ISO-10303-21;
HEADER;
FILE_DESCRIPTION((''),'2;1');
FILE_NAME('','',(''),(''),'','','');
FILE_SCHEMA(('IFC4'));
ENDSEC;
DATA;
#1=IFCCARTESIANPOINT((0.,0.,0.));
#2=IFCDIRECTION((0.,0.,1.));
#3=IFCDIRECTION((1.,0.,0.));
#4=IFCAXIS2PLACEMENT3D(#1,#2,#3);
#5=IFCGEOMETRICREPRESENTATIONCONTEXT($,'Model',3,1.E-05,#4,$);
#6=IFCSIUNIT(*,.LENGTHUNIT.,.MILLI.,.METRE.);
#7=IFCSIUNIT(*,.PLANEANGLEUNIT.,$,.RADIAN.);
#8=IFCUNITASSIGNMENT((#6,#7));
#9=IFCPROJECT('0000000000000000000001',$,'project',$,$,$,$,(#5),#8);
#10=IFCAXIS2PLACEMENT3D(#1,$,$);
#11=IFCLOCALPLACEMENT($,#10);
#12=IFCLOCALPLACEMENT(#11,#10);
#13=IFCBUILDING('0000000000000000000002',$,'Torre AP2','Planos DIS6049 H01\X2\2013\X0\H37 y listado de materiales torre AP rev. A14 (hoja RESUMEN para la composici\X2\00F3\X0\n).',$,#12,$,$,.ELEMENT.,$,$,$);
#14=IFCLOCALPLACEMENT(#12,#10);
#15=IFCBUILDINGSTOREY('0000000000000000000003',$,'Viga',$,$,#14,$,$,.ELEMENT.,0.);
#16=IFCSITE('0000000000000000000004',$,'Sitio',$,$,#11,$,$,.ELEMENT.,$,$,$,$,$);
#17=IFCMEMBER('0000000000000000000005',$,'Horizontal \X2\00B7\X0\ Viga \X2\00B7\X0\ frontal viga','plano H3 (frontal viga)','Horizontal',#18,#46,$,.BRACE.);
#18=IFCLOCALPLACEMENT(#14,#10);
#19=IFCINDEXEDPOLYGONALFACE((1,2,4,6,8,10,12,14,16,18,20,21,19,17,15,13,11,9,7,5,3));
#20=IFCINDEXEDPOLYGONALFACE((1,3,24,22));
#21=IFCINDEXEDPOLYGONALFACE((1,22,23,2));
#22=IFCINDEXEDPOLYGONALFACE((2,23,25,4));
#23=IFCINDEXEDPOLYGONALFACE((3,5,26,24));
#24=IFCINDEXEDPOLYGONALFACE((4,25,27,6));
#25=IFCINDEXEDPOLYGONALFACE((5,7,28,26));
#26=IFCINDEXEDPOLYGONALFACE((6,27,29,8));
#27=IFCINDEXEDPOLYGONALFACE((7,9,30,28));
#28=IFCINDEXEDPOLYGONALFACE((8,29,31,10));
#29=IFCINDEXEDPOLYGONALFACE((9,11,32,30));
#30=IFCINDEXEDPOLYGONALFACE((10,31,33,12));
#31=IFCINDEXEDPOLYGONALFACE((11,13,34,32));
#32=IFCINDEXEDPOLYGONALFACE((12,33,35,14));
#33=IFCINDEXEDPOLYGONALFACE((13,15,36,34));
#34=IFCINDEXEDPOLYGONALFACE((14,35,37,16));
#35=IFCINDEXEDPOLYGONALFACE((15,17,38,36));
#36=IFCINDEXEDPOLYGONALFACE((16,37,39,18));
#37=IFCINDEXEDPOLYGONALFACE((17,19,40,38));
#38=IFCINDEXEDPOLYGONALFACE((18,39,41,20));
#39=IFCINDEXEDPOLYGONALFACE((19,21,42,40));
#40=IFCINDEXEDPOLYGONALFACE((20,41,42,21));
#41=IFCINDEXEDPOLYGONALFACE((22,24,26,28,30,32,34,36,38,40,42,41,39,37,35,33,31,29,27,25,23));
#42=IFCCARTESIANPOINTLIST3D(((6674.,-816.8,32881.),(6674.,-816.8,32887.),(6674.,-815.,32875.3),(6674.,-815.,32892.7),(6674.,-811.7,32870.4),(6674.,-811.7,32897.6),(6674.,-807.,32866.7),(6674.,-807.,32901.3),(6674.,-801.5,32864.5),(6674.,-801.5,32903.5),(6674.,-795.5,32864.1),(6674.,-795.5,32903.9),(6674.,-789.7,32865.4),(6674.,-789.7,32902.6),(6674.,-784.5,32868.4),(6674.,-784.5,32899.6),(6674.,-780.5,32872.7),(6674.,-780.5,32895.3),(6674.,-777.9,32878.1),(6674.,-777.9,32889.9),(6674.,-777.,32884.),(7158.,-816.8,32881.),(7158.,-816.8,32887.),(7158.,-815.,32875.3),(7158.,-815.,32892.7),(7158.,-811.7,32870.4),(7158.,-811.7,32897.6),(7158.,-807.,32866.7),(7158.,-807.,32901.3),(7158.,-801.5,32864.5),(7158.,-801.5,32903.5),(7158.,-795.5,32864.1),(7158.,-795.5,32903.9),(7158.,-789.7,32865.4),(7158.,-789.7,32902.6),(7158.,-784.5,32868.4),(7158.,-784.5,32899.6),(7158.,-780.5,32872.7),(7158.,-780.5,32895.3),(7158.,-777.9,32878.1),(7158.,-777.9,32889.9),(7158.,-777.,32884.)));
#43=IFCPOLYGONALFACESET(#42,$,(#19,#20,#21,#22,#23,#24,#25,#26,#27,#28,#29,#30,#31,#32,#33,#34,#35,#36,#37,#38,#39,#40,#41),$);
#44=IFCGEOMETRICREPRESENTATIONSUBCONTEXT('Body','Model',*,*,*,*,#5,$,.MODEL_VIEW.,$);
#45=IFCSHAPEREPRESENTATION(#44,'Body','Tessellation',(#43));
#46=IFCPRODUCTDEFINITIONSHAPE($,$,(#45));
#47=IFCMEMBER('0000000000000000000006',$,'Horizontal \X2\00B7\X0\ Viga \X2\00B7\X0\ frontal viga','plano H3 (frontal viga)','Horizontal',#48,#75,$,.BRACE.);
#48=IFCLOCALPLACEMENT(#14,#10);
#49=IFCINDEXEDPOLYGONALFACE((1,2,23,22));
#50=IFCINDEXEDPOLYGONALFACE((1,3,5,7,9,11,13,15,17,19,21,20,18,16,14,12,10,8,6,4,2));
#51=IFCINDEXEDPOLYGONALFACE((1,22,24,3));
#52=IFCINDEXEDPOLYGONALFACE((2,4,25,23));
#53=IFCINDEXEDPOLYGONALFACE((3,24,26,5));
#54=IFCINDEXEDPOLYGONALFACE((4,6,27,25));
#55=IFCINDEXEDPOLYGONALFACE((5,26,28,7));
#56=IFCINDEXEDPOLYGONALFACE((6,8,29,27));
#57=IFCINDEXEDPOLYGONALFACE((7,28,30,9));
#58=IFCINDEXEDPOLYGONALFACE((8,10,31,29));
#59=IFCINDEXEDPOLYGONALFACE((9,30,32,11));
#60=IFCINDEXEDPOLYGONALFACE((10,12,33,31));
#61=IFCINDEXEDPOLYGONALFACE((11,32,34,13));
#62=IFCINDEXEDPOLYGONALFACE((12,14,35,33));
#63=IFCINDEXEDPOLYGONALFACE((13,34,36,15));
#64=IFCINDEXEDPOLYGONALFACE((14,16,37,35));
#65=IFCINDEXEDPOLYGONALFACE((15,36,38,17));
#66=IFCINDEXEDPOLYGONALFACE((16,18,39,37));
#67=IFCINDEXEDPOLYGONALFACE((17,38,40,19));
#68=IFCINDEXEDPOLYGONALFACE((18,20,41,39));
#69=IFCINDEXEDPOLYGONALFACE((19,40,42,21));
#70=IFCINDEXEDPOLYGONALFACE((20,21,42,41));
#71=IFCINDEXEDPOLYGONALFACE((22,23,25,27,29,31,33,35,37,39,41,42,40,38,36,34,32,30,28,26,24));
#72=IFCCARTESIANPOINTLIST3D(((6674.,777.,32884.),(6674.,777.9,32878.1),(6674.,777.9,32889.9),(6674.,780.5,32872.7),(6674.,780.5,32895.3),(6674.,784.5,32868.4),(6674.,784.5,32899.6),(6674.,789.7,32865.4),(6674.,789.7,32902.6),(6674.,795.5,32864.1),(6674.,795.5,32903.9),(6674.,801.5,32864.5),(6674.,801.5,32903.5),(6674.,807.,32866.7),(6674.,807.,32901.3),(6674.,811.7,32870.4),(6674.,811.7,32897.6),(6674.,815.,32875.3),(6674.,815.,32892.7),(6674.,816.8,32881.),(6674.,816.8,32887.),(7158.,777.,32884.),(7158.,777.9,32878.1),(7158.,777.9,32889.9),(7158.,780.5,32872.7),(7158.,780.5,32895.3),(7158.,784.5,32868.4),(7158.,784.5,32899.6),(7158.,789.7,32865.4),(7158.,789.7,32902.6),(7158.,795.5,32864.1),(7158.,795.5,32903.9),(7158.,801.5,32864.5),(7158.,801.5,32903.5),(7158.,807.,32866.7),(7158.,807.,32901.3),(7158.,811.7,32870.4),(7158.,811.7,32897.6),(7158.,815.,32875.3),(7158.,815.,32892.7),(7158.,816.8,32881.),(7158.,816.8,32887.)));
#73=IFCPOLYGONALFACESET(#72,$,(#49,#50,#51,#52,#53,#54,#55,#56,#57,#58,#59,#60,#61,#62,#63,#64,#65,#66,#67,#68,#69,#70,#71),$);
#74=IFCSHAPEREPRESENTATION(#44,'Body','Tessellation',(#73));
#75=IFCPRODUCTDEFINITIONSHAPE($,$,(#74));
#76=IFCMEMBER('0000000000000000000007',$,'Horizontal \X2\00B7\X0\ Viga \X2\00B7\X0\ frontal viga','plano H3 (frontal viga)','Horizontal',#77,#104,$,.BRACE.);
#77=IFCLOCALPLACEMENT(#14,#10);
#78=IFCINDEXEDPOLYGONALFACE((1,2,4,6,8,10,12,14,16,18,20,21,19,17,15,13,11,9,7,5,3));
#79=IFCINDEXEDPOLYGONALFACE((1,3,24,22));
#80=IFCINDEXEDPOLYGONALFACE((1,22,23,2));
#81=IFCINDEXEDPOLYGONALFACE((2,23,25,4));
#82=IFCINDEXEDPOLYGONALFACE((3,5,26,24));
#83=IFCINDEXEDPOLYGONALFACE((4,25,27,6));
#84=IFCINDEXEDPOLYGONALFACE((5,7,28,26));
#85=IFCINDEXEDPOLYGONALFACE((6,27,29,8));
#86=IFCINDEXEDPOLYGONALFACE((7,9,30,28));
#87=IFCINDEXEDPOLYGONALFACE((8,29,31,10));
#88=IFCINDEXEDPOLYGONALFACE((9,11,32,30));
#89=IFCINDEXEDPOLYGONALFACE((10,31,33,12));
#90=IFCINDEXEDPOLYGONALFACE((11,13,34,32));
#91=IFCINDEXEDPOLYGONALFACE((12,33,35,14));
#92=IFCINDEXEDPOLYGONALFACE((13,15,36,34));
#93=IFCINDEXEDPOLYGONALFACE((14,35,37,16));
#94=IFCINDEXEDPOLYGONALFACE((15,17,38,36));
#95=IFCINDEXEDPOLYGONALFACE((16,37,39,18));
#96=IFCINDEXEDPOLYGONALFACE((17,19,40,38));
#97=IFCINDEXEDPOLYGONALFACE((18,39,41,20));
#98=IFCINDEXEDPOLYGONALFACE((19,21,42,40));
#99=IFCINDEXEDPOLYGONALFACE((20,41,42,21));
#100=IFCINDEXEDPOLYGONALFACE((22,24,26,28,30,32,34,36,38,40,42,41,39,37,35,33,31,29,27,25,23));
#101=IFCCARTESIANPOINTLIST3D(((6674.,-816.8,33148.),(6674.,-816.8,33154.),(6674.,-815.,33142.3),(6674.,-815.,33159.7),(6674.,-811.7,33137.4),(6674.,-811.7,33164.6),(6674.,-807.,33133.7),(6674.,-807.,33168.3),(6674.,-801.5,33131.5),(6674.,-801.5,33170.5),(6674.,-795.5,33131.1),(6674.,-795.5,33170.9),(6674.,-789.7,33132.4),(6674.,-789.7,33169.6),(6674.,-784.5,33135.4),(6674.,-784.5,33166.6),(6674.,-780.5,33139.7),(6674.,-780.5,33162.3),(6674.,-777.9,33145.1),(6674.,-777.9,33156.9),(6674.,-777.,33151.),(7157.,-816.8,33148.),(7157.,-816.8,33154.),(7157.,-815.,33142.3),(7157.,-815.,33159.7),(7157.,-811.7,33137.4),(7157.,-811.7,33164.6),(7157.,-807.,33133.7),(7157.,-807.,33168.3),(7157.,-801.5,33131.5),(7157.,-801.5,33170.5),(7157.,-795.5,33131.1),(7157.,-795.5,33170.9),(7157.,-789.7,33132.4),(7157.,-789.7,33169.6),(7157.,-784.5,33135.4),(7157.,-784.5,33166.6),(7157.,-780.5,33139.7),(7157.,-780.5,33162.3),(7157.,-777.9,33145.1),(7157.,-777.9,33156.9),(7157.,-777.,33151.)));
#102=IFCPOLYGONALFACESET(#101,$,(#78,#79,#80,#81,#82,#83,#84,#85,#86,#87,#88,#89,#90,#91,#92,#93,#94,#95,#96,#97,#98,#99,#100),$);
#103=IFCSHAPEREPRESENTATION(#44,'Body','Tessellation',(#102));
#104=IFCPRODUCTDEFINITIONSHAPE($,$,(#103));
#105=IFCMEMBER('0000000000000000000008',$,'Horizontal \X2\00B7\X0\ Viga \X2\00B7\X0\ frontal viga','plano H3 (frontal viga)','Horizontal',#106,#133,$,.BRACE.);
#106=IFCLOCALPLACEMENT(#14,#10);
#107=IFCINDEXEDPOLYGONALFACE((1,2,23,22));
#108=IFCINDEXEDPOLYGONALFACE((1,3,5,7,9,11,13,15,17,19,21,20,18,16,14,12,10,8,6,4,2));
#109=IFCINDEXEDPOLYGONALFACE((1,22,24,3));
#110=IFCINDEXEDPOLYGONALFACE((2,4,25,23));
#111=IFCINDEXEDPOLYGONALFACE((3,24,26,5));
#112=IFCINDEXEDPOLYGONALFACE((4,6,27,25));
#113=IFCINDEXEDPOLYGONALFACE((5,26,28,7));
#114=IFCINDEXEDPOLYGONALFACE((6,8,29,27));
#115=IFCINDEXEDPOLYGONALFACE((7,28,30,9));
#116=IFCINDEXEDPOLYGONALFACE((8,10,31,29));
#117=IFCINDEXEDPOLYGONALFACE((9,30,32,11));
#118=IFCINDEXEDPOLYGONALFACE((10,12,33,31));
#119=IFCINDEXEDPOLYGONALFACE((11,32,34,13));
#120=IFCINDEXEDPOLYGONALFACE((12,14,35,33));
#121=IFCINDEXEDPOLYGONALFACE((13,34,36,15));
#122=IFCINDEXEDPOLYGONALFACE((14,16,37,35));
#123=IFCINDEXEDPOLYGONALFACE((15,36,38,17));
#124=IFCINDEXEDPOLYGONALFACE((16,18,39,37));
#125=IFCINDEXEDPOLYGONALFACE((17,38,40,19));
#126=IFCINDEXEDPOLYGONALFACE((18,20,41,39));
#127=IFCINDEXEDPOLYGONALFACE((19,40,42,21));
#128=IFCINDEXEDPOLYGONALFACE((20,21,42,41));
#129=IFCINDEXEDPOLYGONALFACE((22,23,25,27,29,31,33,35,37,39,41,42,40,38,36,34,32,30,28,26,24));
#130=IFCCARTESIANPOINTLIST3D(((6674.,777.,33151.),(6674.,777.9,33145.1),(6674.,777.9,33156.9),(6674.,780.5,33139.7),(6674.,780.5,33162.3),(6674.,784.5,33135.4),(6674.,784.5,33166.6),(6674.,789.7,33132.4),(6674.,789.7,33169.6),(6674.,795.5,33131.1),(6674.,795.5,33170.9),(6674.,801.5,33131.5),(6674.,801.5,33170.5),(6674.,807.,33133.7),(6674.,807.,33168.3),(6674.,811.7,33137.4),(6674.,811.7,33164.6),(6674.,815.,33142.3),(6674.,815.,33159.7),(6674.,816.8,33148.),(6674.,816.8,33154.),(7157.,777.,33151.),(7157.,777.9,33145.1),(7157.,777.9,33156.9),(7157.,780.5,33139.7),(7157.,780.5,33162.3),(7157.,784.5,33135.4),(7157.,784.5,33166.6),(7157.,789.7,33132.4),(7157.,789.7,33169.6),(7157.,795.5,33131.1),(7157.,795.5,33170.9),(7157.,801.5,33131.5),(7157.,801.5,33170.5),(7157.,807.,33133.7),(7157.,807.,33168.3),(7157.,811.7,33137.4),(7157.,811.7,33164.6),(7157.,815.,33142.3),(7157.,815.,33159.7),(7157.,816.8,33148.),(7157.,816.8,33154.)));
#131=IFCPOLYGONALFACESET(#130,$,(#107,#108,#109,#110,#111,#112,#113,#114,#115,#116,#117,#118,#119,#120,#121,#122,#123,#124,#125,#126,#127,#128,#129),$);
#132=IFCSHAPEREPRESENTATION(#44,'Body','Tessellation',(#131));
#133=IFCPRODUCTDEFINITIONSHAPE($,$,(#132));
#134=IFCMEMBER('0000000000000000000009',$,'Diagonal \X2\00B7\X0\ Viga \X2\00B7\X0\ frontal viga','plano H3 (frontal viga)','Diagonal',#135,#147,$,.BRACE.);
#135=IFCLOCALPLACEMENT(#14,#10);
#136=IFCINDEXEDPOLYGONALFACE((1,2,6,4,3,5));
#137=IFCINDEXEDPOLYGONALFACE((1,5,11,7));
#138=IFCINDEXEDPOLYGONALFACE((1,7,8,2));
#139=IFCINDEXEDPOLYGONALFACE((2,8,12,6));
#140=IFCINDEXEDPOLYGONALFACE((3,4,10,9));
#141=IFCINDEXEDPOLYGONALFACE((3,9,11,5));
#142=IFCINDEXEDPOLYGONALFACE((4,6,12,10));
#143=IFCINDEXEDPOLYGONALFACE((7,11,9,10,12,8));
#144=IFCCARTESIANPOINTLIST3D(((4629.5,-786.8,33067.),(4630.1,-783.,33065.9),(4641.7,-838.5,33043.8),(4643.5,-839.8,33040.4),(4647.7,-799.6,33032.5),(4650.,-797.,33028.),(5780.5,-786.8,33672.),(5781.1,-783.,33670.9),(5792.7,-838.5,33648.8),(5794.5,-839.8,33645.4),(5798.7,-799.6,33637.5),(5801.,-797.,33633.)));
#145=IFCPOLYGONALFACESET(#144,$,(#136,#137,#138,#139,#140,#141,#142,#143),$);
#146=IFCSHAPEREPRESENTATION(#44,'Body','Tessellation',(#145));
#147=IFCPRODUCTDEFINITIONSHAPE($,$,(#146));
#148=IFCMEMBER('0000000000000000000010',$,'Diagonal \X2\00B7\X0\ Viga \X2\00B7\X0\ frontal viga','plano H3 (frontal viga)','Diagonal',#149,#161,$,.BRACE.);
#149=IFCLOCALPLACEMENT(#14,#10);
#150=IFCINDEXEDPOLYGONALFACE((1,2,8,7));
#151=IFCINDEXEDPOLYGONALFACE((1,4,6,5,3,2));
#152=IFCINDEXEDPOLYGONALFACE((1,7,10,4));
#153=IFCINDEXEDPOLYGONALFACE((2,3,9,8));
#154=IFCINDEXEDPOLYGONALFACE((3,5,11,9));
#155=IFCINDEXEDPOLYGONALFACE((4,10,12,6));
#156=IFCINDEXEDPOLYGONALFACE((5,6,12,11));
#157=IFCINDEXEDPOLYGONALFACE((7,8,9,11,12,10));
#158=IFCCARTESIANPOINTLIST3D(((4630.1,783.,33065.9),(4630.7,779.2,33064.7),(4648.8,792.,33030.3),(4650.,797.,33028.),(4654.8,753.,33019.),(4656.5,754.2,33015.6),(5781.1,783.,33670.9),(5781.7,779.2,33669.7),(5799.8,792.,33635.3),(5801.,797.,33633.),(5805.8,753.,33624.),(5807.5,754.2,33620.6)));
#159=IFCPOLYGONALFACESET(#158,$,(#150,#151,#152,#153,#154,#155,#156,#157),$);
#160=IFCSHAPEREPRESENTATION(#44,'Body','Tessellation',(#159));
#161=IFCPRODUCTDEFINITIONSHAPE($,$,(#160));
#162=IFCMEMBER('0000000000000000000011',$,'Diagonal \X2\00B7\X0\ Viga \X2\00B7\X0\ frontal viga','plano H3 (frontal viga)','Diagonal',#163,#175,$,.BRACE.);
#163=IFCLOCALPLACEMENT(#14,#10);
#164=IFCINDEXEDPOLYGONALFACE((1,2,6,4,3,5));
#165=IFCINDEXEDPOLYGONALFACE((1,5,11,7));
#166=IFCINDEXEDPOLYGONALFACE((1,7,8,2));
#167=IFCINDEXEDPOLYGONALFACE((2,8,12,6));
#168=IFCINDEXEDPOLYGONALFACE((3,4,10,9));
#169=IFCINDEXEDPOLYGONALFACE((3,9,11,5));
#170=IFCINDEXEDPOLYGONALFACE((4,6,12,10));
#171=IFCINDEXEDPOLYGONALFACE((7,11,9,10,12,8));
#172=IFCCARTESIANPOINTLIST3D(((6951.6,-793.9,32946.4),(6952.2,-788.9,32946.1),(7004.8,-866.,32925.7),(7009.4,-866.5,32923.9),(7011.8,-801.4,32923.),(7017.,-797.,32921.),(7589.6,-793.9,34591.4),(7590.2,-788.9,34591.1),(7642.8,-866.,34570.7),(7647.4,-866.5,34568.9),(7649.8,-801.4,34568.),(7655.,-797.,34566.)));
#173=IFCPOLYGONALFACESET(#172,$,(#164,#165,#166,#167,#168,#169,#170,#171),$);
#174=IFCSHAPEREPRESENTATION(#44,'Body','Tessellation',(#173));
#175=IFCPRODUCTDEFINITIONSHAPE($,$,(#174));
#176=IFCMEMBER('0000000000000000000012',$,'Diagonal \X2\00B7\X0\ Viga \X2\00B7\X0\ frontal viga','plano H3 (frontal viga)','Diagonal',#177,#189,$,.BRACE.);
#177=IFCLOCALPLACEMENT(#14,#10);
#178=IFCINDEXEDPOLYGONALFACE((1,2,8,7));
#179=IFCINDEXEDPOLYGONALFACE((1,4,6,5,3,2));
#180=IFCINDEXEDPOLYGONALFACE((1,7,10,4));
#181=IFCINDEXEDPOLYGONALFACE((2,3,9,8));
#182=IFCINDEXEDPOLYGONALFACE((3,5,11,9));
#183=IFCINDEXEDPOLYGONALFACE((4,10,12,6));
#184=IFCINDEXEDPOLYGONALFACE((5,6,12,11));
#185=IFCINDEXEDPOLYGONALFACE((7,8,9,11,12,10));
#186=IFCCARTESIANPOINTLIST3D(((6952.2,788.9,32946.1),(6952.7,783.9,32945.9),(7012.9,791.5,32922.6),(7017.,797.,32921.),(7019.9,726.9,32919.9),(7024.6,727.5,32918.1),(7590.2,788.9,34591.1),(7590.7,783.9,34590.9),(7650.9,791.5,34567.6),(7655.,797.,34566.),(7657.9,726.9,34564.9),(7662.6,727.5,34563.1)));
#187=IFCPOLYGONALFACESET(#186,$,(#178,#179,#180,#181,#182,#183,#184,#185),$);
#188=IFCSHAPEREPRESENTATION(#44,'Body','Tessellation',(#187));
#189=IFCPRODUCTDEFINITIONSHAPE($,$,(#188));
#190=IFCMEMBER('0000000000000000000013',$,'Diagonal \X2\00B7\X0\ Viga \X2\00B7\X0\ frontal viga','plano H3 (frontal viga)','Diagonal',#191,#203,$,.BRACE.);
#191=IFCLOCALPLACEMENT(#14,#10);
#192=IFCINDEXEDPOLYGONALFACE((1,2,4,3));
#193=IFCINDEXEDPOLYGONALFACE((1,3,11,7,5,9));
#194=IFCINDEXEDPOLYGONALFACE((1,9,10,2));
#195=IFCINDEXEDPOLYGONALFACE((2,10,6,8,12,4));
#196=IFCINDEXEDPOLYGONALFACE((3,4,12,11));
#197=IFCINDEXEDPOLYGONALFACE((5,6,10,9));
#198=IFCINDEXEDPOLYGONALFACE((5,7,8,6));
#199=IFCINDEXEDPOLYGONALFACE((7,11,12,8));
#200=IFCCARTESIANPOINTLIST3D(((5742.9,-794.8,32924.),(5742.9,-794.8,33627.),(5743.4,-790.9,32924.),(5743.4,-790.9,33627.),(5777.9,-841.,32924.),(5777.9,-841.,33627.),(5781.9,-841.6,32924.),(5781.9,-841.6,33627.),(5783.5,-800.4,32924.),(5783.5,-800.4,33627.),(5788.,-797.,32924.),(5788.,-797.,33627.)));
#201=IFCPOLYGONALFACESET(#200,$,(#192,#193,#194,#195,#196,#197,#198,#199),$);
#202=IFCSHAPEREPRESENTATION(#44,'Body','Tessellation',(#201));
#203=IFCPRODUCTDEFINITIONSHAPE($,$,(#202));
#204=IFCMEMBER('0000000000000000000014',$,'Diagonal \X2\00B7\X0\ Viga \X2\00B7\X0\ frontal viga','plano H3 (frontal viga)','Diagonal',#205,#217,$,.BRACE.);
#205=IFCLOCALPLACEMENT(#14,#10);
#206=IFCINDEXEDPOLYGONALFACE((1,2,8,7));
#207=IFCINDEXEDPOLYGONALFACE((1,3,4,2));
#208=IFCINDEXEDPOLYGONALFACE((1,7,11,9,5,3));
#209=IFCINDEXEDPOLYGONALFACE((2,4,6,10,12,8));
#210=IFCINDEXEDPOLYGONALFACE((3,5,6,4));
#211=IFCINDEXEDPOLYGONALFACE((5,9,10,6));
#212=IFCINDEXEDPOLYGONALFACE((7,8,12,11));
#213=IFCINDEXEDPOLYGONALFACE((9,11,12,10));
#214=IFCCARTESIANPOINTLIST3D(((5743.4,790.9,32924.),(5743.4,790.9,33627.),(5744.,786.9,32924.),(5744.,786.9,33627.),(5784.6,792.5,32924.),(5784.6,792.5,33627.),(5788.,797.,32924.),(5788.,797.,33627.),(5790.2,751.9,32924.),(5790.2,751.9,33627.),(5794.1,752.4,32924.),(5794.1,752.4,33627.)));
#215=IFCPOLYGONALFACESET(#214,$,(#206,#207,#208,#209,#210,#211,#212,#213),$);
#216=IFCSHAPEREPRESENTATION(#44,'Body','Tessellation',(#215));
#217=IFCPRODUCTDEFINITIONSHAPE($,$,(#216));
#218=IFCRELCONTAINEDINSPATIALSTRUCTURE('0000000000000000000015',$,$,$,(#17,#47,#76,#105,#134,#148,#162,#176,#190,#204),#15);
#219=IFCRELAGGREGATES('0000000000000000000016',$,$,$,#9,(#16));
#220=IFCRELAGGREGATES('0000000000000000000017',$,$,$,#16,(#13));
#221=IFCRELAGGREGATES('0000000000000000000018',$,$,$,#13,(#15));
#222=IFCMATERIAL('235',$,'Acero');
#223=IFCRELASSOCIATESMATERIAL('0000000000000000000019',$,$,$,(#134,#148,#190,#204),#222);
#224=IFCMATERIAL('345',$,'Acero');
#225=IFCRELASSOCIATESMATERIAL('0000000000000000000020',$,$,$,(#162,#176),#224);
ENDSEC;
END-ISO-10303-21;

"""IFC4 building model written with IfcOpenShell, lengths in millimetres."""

from ifc_helpers import new_model, si_unit, frame, frame_2d, origin, origin_with_axes, place, context, subcontext, project, spatial, circle, l_section, extrude, material, element, save


model = new_model("IFC4")

# Units and contexts
model_context = context("Model", 3, precision=1e-05, world=origin_with_axes())
body_context = subcontext(model_context, "Body", "Model", "MODEL_VIEW")
ifc_project = project(units=[si_unit("LENGTHUNIT", "METRE", prefix="MILLI"), si_unit("PLANEANGLEUNIT", "RADIAN")], contexts=[model_context])

# Site, building, storey
site_placement = place(None, origin())
site = spatial("IfcSite", under=ifc_project, at=site_placement, Name="Sitio", CompositionType="ELEMENT")
building_placement = place(site_placement, origin())
building = spatial("IfcBuilding", under=site, at=building_placement, Name="Torre AP2", Description="Planos DIS6049 H01–H37 y listado de materiales torre AP rev. A14 (hoja RESUMEN para la composición).", CompositionType="ELEMENT")
storey_placement = place(building_placement, origin())
storey = spatial("IfcBuildingStorey", under=building, at=storey_placement, Name="Viga", CompositionType="ELEMENT", Elevation=0.0)

# Members
for number, where, z_axis, x_axis, name in (
    (1, (6674.0, -797.0, 32884.0), (1.0, 0.0, 0.0), (0.0, 1.0, 0.0), "Horizontal · Viga · frontal viga"),
    (2, (6674.0, 797.0, 32884.0), (1.0, 0.0, 0.0), (0.0, -1.0, 0.0), "Horizontal · Viga · frontal viga"),
):
    element("IfcMember", number, at=place(storey_placement, frame(where, z_axis=z_axis, x_axis=x_axis)), inside=storey, Name=name, Description="plano H3 (frontal viga)", ObjectType="Horizontal", PredefinedType="BRACE", context=body_context, shape_type="SweptSolid", body=[
        extrude(circle(Radius=20.0), None, (0.0, 0.0, 1.0), 484.0),
    ])
for number, where, z_axis, x_axis, name in (
    (3, (6674.0, -797.0, 33151.0), (1.0, 0.0, 0.0), (0.0, 1.0, 0.0), "Horizontal · Viga · frontal viga"),
    (4, (6674.0, 797.0, 33151.0), (1.0, 0.0, 0.0), (0.0, -1.0, 0.0), "Horizontal · Viga · frontal viga"),
):
    element("IfcMember", number, at=place(storey_placement, frame(where, z_axis=z_axis, x_axis=x_axis)), inside=storey, Name=name, Description="plano H3 (frontal viga)", ObjectType="Horizontal", PredefinedType="BRACE", context=body_context, shape_type="SweptSolid", body=[
        extrude(circle(Radius=20.0), None, (0.0, 0.0, 1.0), 483.0),
    ])
ifc_material_1 = material(Name="235", Category="Acero")
for number, where, z_axis, x_axis, name in (
    (5, (4650.0, -797.0, 33028.0), (0.885168, 0.0, 0.465271), (-0.442122, 0.311502, 0.841127), "Diagonal · Viga · frontal viga"),
    (6, (4650.0, 797.0, 33028.0), (0.885168, 0.0, 0.465271), (-0.442122, -0.311502, 0.841127), "Diagonal · Viga · frontal viga"),
):
    element("IfcMember", number, at=place(storey_placement, frame(where, z_axis=z_axis, x_axis=x_axis)), inside=storey, material=ifc_material_1, Name=name, Description="plano H3 (frontal viga)", ObjectType="Diagonal", PredefinedType="BRACE", context=body_context, shape_type="SweptSolid", body=[
        extrude(l_section(Depth=45.0, Width=45.0, Thickness=4.0, at=frame_2d((22.5, 22.5))), None, (0.0, 0.0, 1.0), 1300.3),
    ])
ifc_material_2 = material(Name="345", Category="Acero")
for number, where, z_axis, x_axis, name in (
    (7, (7017.0, -797.0, 32921.0), (0.361598, 0.0, 0.932334), (-0.926068, 0.115744, 0.359168), "Diagonal · Viga · frontal viga"),
    (8, (7017.0, 797.0, 32921.0), (0.361598, 0.0, 0.932334), (-0.926068, -0.115744, 0.359168), "Diagonal · Viga · frontal viga"),
):
    element("IfcMember", number, at=place(storey_placement, frame(where, z_axis=z_axis, x_axis=x_axis)), inside=storey, material=ifc_material_2, Name=name, Description="plano H3 (frontal viga)", ObjectType="Diagonal", PredefinedType="BRACE", context=body_context, shape_type="SweptSolid", body=[
        extrude(l_section(Depth=70.0, Width=70.0, Thickness=5.0, at=frame_2d((35.0, 35.0))), None, (0.0, 0.0, 1.0), 1764.4),
    ])
for number, where, z_axis, x_axis, name in (
    (9, (5788.0, -797.0, 32924.0), (0.0, 0.0, 1.0), (-0.990652, 0.136412, 0.0), "Diagonal · Viga · frontal viga"),
    (10, (5788.0, 797.0, 32924.0), (0.0, 0.0, 1.0), (-0.990652, -0.136412, 0.0), "Diagonal · Viga · frontal viga"),
):
    element("IfcMember", number, at=place(storey_placement, frame(where, z_axis=z_axis, x_axis=x_axis)), inside=storey, material=ifc_material_1, Name=name, Description="plano H3 (frontal viga)", ObjectType="Diagonal", PredefinedType="BRACE", context=body_context, shape_type="SweptSolid", body=[
        extrude(l_section(Depth=45.0, Width=45.0, Thickness=4.0, at=frame_2d((22.5, 22.5))), None, (0.0, 0.0, 1.0), 703.0),
    ])

save(model, "model.ifc")
